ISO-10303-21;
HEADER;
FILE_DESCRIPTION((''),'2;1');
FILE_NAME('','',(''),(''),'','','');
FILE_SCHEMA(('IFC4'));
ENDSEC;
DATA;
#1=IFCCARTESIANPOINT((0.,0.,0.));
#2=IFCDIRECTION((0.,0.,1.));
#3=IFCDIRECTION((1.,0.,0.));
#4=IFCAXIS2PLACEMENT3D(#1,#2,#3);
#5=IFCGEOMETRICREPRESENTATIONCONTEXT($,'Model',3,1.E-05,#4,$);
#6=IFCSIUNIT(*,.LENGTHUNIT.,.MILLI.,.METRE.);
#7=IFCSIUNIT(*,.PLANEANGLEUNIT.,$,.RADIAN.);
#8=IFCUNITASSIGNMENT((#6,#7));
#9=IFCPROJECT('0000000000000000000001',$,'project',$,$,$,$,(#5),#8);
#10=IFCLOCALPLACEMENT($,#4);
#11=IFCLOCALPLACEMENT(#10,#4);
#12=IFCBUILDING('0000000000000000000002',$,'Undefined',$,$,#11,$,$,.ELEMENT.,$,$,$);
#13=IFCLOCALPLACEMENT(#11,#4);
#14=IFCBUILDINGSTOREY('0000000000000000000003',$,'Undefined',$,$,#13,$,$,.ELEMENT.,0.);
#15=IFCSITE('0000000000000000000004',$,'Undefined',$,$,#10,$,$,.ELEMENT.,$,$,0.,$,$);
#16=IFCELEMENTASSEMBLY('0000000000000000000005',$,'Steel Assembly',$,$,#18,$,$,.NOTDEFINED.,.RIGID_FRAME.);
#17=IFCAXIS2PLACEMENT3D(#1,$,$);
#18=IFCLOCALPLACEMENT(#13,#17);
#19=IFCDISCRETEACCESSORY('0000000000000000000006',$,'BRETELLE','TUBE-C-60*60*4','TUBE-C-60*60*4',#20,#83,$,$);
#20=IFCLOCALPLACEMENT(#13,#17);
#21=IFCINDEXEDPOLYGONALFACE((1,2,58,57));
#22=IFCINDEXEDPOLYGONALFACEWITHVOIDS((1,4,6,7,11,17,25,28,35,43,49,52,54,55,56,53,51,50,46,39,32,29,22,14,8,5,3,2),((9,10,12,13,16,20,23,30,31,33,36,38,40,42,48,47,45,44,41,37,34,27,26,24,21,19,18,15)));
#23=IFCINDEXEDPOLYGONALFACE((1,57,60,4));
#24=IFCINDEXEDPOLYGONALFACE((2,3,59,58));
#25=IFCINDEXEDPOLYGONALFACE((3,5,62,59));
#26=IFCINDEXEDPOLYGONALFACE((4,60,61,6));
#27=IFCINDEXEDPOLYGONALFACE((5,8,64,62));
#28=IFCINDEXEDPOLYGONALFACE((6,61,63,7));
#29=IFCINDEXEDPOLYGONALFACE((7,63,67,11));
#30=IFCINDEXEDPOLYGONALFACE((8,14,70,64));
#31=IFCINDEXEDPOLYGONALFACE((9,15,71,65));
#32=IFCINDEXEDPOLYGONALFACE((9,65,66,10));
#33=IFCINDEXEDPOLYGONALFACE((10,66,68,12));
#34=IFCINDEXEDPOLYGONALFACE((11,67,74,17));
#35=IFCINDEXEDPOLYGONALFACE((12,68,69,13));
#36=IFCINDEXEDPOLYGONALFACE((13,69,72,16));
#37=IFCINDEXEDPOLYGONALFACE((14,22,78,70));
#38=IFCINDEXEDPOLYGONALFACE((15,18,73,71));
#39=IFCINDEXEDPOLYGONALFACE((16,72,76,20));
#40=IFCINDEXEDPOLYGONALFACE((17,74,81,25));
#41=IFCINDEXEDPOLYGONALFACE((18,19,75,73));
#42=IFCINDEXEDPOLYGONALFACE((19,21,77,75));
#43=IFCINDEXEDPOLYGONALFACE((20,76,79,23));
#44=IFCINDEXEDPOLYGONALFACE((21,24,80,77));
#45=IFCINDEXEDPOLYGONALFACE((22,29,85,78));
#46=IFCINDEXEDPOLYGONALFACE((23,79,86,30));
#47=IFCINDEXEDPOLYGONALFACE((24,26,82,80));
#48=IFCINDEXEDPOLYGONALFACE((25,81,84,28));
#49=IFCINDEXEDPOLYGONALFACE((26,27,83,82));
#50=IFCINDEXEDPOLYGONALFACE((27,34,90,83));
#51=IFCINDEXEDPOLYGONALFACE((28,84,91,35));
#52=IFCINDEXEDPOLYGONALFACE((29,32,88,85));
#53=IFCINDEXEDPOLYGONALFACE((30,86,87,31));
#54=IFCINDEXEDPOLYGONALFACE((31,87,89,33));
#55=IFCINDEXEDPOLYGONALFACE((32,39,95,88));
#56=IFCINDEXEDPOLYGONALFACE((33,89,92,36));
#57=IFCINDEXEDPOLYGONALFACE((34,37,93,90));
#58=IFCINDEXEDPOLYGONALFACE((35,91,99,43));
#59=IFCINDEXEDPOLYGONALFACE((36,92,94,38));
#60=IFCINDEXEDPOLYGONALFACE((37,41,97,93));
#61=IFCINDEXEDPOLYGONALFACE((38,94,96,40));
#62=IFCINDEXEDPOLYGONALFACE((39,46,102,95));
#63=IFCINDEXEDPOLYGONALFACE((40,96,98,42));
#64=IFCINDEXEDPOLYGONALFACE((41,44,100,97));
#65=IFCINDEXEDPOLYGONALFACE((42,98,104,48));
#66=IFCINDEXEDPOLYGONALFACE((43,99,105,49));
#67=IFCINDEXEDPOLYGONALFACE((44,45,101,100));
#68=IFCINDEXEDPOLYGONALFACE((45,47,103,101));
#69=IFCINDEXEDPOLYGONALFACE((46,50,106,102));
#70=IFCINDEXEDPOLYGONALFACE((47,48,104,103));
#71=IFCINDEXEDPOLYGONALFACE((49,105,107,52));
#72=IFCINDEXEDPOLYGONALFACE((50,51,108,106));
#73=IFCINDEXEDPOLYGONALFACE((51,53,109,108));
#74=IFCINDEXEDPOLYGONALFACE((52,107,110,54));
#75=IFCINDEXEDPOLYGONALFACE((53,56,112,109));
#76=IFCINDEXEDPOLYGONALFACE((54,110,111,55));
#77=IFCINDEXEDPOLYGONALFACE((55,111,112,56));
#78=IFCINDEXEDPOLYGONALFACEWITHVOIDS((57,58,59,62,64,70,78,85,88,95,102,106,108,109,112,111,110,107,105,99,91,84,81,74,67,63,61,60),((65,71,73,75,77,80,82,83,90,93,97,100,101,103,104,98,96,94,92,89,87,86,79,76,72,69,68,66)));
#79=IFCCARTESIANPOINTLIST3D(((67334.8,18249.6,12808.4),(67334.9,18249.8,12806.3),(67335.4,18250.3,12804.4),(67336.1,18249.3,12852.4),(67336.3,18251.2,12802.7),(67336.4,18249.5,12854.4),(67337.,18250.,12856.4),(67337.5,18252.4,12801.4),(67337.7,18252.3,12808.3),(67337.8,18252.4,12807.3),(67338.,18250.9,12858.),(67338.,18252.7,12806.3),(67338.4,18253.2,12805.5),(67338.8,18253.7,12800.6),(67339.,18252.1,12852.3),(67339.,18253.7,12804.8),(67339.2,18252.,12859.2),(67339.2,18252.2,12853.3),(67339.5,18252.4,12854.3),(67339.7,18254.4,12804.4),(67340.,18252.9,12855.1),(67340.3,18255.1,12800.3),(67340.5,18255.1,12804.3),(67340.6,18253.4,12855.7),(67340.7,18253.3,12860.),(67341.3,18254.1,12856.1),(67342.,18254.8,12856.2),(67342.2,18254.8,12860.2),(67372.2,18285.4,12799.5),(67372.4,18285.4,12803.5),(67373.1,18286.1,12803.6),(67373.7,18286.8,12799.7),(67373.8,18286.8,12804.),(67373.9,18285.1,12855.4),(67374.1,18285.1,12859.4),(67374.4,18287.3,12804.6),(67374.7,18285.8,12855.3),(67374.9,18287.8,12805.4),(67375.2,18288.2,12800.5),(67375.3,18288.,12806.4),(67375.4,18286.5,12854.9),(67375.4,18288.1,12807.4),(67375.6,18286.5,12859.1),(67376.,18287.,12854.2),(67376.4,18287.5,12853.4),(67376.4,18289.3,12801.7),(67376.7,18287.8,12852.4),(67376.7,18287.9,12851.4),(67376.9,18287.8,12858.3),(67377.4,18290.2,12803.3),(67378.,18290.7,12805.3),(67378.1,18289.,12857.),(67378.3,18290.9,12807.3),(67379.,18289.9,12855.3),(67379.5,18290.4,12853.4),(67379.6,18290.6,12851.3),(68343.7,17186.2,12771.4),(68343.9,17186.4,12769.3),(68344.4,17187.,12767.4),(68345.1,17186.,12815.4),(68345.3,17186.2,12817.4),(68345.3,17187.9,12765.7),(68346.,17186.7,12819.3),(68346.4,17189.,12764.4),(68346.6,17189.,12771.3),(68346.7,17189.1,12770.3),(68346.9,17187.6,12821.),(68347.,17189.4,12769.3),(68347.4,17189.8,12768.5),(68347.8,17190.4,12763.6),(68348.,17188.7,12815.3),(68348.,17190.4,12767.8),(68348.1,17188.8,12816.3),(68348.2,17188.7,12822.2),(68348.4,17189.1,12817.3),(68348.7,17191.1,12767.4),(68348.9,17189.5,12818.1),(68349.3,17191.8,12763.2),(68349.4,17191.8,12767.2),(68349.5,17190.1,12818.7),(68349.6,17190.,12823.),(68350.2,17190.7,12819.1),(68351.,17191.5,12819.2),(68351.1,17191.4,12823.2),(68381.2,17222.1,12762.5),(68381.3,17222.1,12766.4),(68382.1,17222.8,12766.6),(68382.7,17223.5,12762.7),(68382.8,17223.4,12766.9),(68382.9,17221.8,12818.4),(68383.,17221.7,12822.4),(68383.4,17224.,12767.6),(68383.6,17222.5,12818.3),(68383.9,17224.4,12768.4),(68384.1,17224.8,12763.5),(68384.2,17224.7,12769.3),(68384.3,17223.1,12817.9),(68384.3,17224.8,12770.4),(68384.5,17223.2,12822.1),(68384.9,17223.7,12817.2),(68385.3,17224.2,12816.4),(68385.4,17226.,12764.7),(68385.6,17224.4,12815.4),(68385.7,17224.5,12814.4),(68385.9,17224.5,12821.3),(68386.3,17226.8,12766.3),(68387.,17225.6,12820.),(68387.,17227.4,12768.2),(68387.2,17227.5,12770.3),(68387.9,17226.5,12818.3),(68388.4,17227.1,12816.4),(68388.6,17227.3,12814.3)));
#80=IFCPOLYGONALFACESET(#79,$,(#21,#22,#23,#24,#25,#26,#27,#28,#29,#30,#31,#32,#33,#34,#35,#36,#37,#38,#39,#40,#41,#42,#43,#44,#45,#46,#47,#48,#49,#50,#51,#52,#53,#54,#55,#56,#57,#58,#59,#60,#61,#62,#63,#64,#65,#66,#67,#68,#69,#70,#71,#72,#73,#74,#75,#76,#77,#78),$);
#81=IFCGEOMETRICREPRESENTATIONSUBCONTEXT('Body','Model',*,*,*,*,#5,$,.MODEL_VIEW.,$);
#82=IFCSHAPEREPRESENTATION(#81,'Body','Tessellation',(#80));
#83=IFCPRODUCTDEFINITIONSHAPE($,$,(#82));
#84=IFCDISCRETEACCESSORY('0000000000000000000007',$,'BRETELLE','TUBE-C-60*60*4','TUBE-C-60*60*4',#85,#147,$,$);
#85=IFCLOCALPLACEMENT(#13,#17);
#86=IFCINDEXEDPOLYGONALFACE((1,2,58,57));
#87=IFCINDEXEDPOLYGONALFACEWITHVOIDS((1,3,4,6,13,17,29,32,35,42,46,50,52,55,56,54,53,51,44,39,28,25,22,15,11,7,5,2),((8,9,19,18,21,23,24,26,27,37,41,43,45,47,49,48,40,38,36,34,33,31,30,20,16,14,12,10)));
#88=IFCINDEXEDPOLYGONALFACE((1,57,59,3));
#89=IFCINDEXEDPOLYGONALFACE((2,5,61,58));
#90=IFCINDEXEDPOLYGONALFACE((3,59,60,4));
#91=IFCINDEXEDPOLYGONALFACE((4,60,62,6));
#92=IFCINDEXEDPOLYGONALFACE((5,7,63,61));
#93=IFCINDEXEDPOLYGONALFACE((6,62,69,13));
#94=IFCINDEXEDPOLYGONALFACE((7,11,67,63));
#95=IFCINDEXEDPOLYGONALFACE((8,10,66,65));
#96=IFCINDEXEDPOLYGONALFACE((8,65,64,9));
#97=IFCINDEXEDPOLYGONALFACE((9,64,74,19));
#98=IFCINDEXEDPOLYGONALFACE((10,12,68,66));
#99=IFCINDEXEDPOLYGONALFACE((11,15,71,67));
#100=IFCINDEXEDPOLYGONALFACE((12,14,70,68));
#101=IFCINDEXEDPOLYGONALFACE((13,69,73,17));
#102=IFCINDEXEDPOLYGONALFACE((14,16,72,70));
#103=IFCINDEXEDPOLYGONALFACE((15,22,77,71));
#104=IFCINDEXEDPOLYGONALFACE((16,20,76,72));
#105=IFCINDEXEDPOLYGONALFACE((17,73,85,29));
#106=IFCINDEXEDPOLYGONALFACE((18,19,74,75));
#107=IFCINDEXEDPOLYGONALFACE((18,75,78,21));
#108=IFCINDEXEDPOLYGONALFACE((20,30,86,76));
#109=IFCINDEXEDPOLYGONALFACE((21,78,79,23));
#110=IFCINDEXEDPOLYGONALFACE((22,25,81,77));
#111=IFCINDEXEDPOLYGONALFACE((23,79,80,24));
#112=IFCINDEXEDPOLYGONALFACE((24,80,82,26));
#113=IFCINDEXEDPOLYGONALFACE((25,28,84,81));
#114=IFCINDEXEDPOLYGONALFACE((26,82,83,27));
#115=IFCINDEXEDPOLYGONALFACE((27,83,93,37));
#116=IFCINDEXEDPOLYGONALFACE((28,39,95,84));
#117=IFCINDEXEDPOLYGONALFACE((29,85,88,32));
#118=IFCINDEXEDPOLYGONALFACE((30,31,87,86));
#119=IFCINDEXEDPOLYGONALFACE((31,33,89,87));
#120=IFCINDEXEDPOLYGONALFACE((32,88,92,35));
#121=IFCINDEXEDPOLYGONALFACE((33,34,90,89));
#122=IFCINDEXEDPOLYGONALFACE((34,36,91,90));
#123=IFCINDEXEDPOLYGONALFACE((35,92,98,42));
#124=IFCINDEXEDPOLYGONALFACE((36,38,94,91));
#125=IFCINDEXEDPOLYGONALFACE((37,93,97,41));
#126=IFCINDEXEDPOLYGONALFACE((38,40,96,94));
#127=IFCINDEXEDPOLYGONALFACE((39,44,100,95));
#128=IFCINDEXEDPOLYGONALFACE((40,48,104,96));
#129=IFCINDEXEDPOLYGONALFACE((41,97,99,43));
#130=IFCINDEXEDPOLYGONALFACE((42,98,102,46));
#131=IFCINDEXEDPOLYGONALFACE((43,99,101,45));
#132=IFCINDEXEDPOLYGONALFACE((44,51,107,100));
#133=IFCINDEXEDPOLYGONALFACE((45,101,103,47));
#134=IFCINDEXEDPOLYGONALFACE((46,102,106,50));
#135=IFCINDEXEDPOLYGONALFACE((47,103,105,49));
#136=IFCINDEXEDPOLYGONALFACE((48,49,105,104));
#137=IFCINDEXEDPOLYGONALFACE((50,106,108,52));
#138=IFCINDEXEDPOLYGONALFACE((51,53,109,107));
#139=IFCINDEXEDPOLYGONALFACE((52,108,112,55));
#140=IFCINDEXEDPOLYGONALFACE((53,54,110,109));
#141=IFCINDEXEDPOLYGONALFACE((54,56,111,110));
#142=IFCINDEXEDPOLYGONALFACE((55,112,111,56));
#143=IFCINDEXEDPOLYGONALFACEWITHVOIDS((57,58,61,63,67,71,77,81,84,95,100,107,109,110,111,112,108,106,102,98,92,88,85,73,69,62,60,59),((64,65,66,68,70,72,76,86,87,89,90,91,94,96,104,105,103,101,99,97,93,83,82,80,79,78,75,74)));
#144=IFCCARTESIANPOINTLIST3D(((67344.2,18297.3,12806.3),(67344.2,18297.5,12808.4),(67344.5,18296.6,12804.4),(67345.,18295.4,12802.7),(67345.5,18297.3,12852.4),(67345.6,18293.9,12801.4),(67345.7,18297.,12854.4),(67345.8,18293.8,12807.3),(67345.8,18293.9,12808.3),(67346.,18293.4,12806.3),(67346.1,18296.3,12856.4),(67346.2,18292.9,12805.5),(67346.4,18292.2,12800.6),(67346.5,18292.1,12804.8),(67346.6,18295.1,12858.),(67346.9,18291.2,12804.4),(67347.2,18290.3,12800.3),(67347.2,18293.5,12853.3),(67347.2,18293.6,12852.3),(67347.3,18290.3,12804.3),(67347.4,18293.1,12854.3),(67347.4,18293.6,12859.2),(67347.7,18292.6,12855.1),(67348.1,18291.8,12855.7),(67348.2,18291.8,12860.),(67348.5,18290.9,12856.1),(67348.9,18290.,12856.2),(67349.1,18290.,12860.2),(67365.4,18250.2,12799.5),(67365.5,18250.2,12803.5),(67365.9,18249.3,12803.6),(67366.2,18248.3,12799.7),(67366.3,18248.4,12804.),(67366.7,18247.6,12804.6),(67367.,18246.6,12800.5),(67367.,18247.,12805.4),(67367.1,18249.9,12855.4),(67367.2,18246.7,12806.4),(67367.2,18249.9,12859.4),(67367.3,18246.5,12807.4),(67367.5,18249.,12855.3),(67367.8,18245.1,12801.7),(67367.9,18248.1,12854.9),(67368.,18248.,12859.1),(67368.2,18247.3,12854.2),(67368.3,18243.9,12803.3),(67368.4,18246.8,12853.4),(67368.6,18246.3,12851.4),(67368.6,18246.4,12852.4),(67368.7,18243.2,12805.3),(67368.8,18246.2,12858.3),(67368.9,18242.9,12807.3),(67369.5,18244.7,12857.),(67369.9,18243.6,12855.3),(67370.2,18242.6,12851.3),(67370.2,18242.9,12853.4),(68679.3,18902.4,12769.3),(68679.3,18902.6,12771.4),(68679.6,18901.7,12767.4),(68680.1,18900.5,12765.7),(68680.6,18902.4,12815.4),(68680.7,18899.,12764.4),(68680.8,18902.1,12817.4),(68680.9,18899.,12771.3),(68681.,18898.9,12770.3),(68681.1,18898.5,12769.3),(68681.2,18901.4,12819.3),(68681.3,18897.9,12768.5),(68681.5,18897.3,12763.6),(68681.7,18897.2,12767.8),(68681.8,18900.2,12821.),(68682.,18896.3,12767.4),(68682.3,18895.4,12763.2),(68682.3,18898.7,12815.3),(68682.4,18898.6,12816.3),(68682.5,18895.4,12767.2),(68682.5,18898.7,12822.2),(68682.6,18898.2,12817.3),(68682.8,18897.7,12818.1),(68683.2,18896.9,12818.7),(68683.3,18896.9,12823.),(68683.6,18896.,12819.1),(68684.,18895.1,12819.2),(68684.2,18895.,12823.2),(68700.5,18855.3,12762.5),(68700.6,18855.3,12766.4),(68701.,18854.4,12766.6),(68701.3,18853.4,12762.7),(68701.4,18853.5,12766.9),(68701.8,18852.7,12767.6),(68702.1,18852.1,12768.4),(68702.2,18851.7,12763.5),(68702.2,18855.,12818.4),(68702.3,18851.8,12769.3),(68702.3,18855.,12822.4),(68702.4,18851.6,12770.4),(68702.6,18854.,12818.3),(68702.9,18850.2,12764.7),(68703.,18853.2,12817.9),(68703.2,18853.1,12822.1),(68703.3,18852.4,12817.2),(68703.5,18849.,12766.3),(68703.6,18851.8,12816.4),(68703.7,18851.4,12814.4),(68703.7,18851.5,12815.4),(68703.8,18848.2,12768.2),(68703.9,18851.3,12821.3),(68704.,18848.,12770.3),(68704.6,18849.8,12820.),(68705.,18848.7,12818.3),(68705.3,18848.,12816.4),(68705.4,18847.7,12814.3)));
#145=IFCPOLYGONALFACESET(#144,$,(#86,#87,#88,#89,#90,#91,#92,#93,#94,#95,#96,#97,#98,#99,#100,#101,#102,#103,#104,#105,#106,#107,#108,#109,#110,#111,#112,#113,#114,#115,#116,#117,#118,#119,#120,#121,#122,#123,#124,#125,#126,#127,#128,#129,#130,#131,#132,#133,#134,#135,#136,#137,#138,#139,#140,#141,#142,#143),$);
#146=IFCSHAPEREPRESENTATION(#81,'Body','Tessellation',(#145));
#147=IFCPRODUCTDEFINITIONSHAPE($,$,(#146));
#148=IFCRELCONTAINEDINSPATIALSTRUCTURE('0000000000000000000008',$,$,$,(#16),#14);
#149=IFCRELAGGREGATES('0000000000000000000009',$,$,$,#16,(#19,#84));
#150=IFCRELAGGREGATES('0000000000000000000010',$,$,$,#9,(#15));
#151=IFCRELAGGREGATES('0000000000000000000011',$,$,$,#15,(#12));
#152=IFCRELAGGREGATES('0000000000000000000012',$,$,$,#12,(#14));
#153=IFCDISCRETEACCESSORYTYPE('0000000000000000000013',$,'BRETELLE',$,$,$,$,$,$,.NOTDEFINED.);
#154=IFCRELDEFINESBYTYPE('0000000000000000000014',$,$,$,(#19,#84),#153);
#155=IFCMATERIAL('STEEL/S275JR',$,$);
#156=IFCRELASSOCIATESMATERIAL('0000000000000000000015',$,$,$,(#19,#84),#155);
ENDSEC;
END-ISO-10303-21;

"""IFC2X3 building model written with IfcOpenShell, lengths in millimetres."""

from ifc_helpers import new_model, si_unit, frame, origin_with_axes, origin_2d_with_axis, place, context, subcontext, project, spatial, hollow_rectangle, extrude, material, type_object, element, aggregate, save


model = new_model("IFC2X3")

# Units and contexts
model_context = context("Model", 3, precision=1e-05, world=origin_with_axes())
body_context = subcontext(model_context, "Body", "Model", "MODEL_VIEW")
ifc_project = project(units=[si_unit("LENGTHUNIT", "METRE", prefix="MILLI"), si_unit("PLANEANGLEUNIT", "RADIAN")], contexts=[model_context])

# Site, building, storey
site_placement = place(None, origin_with_axes())
site = spatial("IfcSite", under=ifc_project, at=site_placement, Name="Undefined", CompositionType="ELEMENT", RefElevation=0.0)
building_placement = place(site_placement, origin_with_axes())
building = spatial("IfcBuilding", under=site, at=building_placement, Name="Undefined", CompositionType="ELEMENT")
storey_placement = place(building_placement, origin_with_axes())
storey = spatial("IfcBuildingStorey", under=building, at=storey_placement, Name="Undefined", CompositionType="ELEMENT", Elevation=0.0)

# Shared definitions
ifc_material = material(Name="STEEL/S275JR")

# Element assembly, discrete accessories
assembly_1_placement = place(storey_placement, origin_with_axes())
assembly_1 = element("IfcElementAssembly", 1, at=assembly_1_placement, inside=storey, Name="Steel Assembly", AssemblyPlace="NOTDEFINED", PredefinedType="RIGID_FRAME")
discrete_accessory_type_1 = type_object("IfcDiscreteAccessoryType", Name="BRETELLE")
discrete_accessory_1_placement = place(assembly_1_placement, frame((67357.2, 18270.1, 12829.9), z_axis=(0.724985, 0.68853, -0.017961), x_axis=(0.688093, -0.725184, -0.025247)))
discrete_accessory_1 = element("IfcDiscreteAccessory", 2, at=discrete_accessory_1_placement, type_object=discrete_accessory_type_1, material=ifc_material, Name="BRETELLE", Description="TUBE-C-60*60*4", ObjectType="TUBE-C-60*60*4", context=body_context, shape_type="SweptSolid", body=[
    extrude(hollow_rectangle(XDim=60.0, YDim=60.0, WallThickness=4.0, InnerFilletRadius=4.0, OuterFilletRadius=8.0, at=origin_2d_with_axis()), frame((1466.3, 0.0, 0.0), z_axis=(-1.0, 0.0, 0.0), x_axis=(0.0, -1.0, 0.0)), (0.0, 0.0, 1.0), 1466.3),
])
discrete_accessory_2_placement = place(assembly_1_placement, frame((68692.3, 18875.2, 12792.8), z_axis=(-0.412318, 0.910863, 0.017961), x_axis=(-0.910532, -0.412666, 0.025247)))
discrete_accessory_2 = element("IfcDiscreteAccessory", 3, at=discrete_accessory_2_placement, type_object=discrete_accessory_type_1, material=ifc_material, Name="BRETELLE", Description="TUBE-C-60*60*4", ObjectType="TUBE-C-60*60*4", context=body_context, shape_type="SweptSolid", body=[
    extrude(hollow_rectangle(XDim=60.0, YDim=60.0, WallThickness=4.0, InnerFilletRadius=4.0, OuterFilletRadius=8.0, at=origin_2d_with_axis()), frame((1466.3, 0.0, 0.0), z_axis=(-1.0, 0.0, 0.0), x_axis=(0.0, -1.0, 0.0)), (0.0, 0.0, 1.0), 1466.3),
])
aggregate(assembly_1, [discrete_accessory_1, discrete_accessory_2])

save(model, "model.ifc")
